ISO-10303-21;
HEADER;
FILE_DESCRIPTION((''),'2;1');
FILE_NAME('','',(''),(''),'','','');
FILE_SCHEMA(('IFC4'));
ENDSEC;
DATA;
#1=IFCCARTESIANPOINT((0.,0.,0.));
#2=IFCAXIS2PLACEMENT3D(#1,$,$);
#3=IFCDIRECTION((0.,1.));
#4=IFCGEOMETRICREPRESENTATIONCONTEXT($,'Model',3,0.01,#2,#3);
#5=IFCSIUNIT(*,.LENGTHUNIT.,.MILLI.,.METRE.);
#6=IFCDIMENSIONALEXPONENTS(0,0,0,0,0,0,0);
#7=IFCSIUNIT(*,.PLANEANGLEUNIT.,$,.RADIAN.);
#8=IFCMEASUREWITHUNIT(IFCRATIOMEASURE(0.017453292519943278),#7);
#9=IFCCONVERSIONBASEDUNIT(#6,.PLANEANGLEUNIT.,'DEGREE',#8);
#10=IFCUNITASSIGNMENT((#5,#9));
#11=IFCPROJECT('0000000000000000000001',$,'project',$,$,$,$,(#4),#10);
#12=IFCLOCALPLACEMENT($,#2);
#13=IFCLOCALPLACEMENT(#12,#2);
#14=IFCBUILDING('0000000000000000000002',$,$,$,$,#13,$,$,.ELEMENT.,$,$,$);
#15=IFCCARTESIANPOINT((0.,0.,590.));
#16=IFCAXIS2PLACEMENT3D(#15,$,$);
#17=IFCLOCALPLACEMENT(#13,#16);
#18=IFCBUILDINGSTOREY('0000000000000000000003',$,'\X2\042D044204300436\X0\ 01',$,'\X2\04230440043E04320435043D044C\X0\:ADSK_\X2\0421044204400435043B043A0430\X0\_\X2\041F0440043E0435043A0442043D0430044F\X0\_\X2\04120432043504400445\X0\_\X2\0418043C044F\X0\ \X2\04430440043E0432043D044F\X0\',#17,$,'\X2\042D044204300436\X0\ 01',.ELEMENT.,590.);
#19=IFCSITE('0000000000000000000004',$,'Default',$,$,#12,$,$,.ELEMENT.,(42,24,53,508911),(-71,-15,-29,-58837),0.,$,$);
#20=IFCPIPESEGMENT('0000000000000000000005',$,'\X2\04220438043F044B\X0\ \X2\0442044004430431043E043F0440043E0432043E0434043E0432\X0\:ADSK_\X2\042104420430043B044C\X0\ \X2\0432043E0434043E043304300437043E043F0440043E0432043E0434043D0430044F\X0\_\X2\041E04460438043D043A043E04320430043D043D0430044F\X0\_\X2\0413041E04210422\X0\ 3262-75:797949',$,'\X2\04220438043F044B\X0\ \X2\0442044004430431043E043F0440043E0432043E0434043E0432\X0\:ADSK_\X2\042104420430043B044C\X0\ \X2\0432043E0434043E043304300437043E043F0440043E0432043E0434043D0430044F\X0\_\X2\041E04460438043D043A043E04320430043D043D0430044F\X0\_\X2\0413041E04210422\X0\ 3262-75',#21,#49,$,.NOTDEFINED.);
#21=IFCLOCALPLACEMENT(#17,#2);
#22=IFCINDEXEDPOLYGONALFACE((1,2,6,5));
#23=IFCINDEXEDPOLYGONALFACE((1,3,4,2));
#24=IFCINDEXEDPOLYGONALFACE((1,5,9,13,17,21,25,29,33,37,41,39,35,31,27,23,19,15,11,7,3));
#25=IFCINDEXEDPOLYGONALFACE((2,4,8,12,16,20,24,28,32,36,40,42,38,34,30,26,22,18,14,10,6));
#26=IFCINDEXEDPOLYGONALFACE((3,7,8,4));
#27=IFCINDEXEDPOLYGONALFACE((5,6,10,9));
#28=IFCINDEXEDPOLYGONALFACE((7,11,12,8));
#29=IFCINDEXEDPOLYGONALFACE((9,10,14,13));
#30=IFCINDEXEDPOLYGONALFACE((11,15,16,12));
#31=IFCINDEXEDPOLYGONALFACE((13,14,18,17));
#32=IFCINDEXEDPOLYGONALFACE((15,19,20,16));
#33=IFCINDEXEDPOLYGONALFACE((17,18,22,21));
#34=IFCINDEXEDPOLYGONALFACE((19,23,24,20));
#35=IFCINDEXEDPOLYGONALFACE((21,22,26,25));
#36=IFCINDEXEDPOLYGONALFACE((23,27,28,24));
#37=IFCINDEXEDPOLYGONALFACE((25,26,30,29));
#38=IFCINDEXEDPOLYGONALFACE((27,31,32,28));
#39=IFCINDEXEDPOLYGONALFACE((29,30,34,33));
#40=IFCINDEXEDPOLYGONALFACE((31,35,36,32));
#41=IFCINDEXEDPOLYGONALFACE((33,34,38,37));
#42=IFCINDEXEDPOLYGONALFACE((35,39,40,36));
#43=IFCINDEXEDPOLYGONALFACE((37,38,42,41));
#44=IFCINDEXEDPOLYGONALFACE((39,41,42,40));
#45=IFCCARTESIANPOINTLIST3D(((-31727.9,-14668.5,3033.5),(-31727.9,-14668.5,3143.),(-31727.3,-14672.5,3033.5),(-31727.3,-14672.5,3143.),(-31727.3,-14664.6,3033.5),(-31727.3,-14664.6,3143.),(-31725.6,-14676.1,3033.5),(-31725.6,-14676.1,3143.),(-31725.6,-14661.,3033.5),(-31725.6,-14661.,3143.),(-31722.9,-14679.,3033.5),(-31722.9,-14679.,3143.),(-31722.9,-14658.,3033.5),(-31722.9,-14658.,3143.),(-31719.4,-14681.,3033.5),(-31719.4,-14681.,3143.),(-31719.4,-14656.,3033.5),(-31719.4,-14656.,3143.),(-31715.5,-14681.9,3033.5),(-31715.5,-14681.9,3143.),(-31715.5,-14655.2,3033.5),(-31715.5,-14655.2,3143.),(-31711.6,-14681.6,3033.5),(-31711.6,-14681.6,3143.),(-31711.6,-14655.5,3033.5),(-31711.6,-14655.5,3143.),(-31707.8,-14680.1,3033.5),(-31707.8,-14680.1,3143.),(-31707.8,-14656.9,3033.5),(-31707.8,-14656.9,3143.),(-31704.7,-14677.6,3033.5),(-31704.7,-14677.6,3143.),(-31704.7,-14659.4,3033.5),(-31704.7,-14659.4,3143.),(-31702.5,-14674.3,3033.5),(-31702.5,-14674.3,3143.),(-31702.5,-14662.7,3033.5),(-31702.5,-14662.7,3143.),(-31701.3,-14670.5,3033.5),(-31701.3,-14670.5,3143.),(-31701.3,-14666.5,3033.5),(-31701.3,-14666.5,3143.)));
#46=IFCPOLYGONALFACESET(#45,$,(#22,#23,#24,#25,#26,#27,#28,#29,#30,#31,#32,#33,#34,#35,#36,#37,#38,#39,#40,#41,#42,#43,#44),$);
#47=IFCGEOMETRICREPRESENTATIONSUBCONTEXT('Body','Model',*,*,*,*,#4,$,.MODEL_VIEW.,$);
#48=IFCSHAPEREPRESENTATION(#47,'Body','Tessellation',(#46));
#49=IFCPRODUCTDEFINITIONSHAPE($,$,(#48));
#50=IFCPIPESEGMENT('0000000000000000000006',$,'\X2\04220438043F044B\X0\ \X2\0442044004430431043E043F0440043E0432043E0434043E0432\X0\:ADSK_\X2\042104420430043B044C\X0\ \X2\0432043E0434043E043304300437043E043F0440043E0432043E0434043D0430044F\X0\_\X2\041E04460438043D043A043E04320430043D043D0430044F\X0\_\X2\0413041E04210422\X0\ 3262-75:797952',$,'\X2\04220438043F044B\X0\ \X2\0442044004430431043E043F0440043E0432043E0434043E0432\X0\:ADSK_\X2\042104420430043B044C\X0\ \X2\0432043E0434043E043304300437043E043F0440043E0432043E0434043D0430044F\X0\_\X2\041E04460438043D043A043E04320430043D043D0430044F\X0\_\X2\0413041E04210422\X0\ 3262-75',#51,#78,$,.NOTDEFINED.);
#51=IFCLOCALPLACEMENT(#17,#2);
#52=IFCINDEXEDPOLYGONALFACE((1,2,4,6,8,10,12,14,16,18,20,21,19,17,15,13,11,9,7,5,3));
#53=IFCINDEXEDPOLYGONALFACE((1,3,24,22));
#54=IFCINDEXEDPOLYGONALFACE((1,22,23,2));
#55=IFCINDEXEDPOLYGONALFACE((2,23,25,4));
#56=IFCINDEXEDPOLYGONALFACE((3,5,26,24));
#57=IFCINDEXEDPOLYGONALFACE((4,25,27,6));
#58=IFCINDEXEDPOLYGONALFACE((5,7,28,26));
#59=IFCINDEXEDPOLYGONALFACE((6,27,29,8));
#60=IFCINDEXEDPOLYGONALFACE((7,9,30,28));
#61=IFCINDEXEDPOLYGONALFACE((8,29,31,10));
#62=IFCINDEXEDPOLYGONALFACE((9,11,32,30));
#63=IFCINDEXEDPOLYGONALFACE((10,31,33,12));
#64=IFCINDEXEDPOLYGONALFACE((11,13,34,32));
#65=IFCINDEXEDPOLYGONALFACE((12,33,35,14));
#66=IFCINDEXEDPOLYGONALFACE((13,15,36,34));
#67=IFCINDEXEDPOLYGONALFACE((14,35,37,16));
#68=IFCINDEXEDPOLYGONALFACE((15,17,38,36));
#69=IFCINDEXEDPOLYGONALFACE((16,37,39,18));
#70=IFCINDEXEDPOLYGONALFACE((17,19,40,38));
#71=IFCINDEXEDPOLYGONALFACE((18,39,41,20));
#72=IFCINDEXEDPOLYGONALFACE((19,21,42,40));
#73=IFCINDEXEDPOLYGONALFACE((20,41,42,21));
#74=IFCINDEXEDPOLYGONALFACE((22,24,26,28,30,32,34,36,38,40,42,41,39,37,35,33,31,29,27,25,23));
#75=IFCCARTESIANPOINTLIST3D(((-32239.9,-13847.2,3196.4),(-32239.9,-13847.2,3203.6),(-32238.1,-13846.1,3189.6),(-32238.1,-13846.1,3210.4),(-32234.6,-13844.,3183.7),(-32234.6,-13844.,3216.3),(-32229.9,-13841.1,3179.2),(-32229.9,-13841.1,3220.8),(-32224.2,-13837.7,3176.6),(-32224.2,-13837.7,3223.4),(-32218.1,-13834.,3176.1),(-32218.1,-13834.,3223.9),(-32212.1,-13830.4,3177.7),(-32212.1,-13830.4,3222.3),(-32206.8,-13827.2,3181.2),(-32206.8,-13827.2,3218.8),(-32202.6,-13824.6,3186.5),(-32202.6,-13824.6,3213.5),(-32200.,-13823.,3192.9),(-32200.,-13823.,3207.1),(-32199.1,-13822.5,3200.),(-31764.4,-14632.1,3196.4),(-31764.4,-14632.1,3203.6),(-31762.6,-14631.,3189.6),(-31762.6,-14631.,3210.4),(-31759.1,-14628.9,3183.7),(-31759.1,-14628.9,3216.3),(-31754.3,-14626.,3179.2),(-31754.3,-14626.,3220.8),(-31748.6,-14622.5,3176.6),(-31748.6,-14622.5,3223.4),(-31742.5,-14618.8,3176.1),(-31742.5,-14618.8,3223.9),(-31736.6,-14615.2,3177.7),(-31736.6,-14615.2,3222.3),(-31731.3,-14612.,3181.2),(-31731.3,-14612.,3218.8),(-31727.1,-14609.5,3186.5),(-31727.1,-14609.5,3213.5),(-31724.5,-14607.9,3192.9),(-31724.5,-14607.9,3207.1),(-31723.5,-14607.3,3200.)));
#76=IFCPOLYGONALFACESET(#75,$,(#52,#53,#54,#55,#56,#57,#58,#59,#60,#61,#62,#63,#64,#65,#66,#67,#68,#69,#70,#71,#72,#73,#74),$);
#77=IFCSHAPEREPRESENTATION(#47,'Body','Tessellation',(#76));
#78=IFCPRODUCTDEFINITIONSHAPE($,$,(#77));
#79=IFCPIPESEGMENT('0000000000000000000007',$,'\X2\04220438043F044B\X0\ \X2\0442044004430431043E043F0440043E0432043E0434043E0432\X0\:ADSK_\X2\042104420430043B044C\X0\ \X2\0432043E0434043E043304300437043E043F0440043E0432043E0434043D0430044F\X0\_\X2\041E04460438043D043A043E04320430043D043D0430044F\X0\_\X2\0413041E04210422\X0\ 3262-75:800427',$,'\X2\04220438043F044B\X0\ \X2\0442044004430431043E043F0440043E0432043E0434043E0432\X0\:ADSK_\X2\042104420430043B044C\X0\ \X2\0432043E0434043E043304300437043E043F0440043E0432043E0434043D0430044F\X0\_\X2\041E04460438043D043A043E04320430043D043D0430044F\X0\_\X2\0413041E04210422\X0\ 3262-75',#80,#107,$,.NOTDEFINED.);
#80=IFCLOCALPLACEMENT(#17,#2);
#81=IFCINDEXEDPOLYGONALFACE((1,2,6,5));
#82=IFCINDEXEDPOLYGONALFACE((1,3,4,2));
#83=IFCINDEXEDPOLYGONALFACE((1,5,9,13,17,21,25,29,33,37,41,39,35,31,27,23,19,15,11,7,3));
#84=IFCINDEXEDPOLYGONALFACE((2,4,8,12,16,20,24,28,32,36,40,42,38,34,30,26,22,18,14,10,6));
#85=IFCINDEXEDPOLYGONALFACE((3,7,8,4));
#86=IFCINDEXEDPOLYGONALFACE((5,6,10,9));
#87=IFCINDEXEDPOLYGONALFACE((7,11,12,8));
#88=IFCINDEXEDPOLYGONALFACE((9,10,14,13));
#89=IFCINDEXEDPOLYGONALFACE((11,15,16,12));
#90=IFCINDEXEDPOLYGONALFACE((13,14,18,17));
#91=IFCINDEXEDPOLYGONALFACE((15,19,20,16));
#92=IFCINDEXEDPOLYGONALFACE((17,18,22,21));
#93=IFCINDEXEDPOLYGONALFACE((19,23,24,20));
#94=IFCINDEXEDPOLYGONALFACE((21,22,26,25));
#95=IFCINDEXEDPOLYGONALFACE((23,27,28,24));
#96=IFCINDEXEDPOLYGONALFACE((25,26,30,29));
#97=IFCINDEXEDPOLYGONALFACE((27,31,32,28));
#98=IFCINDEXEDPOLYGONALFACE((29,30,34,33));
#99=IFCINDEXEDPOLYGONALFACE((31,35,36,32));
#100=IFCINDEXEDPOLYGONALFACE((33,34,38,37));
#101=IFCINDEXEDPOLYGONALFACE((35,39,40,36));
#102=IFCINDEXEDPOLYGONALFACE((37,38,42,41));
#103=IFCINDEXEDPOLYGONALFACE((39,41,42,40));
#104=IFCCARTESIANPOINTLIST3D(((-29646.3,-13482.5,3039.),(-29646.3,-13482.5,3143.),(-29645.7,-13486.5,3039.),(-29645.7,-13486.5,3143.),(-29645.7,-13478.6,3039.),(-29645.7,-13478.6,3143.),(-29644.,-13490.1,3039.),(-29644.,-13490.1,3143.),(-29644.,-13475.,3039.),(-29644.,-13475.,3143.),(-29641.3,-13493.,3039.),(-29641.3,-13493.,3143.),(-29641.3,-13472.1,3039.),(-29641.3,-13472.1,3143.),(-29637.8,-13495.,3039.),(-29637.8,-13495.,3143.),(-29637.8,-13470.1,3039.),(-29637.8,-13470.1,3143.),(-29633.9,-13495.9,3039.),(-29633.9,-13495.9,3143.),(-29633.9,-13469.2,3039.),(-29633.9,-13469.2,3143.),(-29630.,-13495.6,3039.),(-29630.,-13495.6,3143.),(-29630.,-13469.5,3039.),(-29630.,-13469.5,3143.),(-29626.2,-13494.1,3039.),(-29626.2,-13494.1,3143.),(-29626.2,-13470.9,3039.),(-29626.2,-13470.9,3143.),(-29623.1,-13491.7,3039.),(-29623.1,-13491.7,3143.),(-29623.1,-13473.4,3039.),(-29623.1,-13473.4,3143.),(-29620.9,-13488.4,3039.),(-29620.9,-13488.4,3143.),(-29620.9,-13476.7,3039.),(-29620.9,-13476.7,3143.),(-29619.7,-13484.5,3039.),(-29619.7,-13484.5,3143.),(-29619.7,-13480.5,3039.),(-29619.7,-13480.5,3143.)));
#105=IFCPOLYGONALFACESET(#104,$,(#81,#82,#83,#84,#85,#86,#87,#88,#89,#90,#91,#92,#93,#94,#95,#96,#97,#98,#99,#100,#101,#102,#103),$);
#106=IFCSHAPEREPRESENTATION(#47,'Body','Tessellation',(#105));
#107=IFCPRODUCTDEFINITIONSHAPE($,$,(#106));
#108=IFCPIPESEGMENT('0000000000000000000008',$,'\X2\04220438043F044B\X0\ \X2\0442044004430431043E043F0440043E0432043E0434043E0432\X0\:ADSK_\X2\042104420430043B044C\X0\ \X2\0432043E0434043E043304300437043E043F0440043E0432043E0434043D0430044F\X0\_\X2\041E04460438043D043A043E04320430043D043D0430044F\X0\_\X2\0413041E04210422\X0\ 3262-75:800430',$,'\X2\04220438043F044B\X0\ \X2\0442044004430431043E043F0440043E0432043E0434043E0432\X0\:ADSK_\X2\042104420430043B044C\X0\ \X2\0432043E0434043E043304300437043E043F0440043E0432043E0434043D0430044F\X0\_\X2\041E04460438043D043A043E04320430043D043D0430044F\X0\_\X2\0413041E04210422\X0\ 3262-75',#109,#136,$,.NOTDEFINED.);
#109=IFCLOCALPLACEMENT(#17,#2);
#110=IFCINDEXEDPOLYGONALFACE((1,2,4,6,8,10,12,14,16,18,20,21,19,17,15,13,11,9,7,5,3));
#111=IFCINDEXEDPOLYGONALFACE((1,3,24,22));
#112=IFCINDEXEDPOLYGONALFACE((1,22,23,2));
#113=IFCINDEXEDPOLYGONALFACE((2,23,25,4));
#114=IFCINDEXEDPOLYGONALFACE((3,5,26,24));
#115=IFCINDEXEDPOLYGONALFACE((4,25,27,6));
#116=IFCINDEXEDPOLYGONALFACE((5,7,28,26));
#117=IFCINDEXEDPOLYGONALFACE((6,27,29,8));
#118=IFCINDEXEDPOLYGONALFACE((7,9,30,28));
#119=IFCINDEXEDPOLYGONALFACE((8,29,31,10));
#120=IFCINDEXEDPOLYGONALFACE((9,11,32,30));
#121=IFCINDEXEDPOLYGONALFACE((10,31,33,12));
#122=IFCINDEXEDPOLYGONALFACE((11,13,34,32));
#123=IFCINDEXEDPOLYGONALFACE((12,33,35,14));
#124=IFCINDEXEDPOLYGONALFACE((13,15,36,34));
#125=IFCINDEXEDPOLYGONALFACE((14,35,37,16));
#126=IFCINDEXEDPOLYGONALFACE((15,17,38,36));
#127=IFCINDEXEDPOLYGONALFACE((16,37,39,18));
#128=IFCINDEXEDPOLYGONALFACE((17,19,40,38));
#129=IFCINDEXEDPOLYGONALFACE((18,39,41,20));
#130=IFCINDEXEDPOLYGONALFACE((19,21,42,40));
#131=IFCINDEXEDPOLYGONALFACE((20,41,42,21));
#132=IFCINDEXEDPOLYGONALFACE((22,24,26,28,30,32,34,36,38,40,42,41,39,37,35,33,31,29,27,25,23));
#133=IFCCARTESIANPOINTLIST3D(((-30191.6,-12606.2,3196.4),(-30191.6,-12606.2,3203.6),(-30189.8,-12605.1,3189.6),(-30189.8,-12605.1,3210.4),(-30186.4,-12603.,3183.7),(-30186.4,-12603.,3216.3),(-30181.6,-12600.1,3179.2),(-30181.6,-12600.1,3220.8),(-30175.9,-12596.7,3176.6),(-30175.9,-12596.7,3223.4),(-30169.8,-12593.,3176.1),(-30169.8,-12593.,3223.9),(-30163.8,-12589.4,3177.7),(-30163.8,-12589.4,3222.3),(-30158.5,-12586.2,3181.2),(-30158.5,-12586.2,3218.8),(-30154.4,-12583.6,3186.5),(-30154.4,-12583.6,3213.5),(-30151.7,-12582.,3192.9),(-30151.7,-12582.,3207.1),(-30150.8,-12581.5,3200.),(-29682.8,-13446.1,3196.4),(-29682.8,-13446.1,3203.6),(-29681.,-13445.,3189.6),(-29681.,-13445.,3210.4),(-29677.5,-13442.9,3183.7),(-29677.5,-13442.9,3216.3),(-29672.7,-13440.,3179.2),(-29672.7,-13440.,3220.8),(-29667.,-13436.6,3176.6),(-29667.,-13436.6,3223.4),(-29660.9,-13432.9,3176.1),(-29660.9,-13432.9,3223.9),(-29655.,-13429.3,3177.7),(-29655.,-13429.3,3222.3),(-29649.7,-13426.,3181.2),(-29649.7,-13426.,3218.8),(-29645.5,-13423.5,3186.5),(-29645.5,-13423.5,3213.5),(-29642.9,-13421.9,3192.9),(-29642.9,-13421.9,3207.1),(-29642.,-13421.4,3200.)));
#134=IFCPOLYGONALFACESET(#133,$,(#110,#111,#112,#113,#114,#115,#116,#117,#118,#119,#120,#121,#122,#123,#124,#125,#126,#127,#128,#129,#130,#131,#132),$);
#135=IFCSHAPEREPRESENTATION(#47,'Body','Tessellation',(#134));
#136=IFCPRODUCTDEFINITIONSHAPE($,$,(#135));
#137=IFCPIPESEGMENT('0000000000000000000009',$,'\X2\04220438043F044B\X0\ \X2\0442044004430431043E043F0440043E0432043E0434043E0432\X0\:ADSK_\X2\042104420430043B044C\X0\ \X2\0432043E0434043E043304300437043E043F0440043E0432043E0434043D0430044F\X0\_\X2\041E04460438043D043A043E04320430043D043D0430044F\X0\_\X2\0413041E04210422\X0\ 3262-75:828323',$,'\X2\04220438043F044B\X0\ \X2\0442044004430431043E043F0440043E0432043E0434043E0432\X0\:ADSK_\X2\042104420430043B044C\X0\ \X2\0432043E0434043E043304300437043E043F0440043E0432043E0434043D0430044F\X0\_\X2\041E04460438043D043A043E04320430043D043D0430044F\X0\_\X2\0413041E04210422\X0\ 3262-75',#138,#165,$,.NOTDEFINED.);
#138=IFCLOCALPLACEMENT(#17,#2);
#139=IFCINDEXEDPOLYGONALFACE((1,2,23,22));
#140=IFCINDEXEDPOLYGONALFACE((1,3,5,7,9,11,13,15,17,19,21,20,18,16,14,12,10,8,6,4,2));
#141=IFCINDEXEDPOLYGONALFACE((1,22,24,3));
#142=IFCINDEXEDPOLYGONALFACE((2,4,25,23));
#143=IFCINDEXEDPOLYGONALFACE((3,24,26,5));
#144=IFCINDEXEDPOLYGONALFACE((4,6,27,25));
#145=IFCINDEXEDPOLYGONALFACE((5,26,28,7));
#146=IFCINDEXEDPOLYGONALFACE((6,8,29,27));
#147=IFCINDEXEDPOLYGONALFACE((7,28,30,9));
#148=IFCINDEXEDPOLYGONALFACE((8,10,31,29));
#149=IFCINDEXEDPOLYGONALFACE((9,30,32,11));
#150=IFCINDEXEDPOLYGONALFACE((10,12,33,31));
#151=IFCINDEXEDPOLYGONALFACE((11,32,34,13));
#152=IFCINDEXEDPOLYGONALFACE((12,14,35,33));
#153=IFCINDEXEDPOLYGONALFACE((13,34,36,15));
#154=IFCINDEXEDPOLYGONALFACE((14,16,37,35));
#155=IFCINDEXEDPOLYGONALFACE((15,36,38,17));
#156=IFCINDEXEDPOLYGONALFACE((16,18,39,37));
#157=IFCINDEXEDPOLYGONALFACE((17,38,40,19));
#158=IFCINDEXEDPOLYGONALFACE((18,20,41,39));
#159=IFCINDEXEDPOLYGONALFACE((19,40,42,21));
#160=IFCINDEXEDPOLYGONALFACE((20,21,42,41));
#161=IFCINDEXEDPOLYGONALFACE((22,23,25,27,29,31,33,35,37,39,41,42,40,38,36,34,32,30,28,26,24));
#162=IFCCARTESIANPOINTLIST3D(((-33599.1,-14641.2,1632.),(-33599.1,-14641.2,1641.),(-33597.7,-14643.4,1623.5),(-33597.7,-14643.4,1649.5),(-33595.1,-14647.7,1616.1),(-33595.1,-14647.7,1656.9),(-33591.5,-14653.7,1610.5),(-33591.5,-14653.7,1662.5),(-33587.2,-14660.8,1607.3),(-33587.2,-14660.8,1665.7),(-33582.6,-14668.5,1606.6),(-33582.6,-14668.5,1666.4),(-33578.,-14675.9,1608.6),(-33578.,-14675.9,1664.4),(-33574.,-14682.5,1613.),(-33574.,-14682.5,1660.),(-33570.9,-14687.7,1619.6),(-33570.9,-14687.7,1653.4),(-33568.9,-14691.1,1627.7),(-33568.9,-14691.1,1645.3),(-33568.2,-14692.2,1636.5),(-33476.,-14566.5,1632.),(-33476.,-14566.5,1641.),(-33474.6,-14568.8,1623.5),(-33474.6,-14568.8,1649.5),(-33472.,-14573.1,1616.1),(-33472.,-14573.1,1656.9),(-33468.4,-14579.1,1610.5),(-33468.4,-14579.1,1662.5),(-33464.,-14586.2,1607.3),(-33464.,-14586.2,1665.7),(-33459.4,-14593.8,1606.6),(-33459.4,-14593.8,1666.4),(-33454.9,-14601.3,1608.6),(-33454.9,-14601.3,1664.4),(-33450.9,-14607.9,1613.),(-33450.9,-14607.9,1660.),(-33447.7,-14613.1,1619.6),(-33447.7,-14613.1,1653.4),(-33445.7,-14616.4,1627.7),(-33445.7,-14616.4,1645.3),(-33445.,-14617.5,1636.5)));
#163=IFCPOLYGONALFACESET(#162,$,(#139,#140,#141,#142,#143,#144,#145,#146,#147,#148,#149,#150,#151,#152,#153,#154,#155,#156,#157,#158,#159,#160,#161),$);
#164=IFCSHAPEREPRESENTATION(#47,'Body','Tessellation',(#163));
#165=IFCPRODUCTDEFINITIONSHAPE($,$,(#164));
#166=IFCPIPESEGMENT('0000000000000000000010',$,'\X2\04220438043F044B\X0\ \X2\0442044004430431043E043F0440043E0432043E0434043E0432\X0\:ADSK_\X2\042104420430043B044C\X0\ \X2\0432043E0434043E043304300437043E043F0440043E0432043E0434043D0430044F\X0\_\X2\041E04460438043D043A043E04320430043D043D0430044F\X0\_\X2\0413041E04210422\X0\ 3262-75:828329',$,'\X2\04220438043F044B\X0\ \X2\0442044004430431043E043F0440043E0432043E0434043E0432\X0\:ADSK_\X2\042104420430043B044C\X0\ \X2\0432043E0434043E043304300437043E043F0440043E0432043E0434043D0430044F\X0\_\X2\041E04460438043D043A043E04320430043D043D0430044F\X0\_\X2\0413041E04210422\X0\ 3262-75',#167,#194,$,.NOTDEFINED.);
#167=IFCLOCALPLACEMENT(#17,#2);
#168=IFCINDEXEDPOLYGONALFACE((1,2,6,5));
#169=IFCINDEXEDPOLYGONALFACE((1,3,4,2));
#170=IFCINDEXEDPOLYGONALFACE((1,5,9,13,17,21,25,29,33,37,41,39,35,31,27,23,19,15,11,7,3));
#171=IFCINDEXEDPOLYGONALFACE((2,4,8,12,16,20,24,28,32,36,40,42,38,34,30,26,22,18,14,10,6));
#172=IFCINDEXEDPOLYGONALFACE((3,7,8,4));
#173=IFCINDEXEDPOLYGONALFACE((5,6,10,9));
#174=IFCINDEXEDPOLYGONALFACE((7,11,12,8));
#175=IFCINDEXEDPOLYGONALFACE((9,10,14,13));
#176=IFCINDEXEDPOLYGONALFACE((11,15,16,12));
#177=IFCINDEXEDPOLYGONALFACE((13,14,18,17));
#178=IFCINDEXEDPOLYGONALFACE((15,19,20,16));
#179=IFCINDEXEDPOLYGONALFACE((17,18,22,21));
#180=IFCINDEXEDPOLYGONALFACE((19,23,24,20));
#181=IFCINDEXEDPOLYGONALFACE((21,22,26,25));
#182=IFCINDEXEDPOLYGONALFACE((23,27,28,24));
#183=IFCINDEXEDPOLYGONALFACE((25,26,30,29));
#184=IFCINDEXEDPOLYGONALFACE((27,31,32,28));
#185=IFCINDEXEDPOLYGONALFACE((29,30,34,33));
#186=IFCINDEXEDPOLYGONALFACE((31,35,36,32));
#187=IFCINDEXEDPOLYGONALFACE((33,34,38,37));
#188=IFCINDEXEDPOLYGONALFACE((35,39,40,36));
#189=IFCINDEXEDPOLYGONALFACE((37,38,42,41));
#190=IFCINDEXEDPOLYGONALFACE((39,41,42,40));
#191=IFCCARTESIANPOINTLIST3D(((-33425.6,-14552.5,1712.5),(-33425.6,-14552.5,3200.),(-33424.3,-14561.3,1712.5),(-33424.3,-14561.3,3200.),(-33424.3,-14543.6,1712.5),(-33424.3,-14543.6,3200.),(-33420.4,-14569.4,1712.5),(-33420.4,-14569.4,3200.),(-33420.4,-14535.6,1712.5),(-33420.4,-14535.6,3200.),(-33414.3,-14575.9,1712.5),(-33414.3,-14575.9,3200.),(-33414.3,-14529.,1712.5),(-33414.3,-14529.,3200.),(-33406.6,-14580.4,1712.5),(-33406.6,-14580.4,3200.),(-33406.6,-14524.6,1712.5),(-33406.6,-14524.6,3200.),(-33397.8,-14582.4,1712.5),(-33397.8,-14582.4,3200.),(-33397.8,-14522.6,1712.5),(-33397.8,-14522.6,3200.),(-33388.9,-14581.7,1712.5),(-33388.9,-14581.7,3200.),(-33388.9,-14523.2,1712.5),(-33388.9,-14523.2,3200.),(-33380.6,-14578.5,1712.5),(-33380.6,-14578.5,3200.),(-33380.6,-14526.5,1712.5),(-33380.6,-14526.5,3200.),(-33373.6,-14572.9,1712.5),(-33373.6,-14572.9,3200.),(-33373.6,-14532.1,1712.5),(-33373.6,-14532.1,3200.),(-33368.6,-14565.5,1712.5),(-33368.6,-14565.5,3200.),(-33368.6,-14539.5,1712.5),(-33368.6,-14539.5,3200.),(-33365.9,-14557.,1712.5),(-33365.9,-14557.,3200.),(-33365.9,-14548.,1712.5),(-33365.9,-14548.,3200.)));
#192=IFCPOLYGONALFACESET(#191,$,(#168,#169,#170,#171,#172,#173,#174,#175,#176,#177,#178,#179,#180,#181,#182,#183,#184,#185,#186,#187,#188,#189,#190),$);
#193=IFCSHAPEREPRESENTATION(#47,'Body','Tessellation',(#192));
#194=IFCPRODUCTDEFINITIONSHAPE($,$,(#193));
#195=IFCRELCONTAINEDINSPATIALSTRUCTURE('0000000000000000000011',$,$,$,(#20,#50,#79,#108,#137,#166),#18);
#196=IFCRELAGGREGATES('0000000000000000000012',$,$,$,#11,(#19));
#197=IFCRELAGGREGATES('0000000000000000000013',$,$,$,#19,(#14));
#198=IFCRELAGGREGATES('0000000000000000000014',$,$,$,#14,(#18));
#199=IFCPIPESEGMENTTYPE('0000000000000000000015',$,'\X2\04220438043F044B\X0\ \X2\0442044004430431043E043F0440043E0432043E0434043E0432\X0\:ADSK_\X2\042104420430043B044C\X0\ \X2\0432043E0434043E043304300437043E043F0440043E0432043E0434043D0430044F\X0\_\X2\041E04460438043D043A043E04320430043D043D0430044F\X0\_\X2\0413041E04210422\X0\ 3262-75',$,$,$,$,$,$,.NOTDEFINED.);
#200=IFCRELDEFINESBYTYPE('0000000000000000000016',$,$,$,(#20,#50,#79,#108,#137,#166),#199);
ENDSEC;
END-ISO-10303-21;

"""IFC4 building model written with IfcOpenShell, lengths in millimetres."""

from ifc_helpers import new_model, entity, si_unit, converted_unit, direction, frame, frame_2d, origin, origin_2d_with_axis, place, context, subcontext, project, spatial, circle, extrude, type_object, element, save


model = new_model("IFC4")

# Units and contexts
model_context = context("Model", 3, precision=0.01, world=origin(), true_north=direction((0.0, 1.0)))
body_context = subcontext(model_context, "Body", "Model", "MODEL_VIEW")
ifc_project = project(units=[si_unit("LENGTHUNIT", "METRE", prefix="MILLI"), converted_unit("PLANEANGLEUNIT", "DEGREE", entity("IfcRatioMeasure", 0.017453292519943278), si_unit("PLANEANGLEUNIT", "RADIAN"), dimensions=[0, 0, 0, 0, 0, 0, 0])], contexts=[model_context])

# Site, building, storey
site_placement = place(None, origin())
site = spatial("IfcSite", under=ifc_project, at=site_placement, Name="Default", CompositionType="ELEMENT", RefLatitude=(42, 24, 53, 508911), RefLongitude=(-71, -15, -29, -58837), RefElevation=0.0)
building_placement = place(site_placement, origin())
building = spatial("IfcBuilding", under=site, at=building_placement, CompositionType="ELEMENT")
storey_placement = place(building_placement, frame((0.0, 0.0, 590.0)))
storey = spatial("IfcBuildingStorey", under=building, at=storey_placement, Name="Этаж 01", ObjectType="Уровень:ADSK_Стрелка_Проектная_Вверх_Имя уровня", LongName="Этаж 01", CompositionType="ELEMENT", Elevation=590.0)

# Pipe segments
pipe_segment_type = type_object("IfcPipeSegmentType", Name="Типы трубопроводов:ADSK_Сталь водогазопроводная_Оцинкованная_ГОСТ 3262-75", PredefinedType="NOTDEFINED")
pipe_segment_1_placement = place(storey_placement, frame((-31729.5, -14683.5, 3143.0)))
element("IfcPipeSegment", 1, at=pipe_segment_1_placement, inside=storey, type_object=pipe_segment_type, Name="Типы трубопроводов:ADSK_Сталь водогазопроводная_Оцинкованная_ГОСТ 3262-75:797949", ObjectType="Типы трубопроводов:ADSK_Сталь водогазопроводная_Оцинкованная_ГОСТ 3262-75", PredefinedType="NOTDEFINED", context=body_context, shape_type="SweptSolid", body=[
    extrude(circle(Radius=13.4, at=frame_2d((0.0, 0.0), x_axis=(1.0, 0.0))), frame((15.0, 15.0, -109.5), z_axis=(0.0, 0.0, 1.0), x_axis=(-1.0, 0.0, 0.0)), (0.0, 0.0, 1.0), 109.5),
])
pipe_segment_2_placement = place(storey_placement, frame((-32241.7, -14633.8, 3174.4)))
element("IfcPipeSegment", 2, at=pipe_segment_2_placement, inside=storey, type_object=pipe_segment_type, Name="Типы трубопроводов:ADSK_Сталь водогазопроводная_Оцинкованная_ГОСТ 3262-75:797952", ObjectType="Типы трубопроводов:ADSK_Сталь водогазопроводная_Оцинкованная_ГОСТ 3262-75", PredefinedType="NOTDEFINED", context=body_context, shape_type="SweptSolid", body=[
    extrude(circle(Radius=24.0, at=origin_2d_with_axis()), frame((22.1, 798.9, 25.6), z_axis=(0.518188, -0.855267, 0.0), x_axis=(0.855267, 0.518188, 0.0)), (0.0, 0.0, 1.0), 917.7),
])
pipe_segment_3_placement = place(storey_placement, frame((-29647.9, -13497.5, 3143.0)))
element("IfcPipeSegment", 3, at=pipe_segment_3_placement, inside=storey, type_object=pipe_segment_type, Name="Типы трубопроводов:ADSK_Сталь водогазопроводная_Оцинкованная_ГОСТ 3262-75:800427", ObjectType="Типы трубопроводов:ADSK_Сталь водогазопроводная_Оцинкованная_ГОСТ 3262-75", PredefinedType="NOTDEFINED", context=body_context, shape_type="SweptSolid", body=[
    extrude(circle(Radius=13.4, at=origin_2d_with_axis()), frame((15.0, 15.0, -104.0), z_axis=(0.0, 0.0, 1.0), x_axis=(-1.0, 0.0, 0.0)), (0.0, 0.0, 1.0), 104.0),
])
pipe_segment_4_placement = place(storey_placement, frame((-30193.5, -13447.8, 3174.4)))
element("IfcPipeSegment", 4, at=pipe_segment_4_placement, inside=storey, type_object=pipe_segment_type, Name="Типы трубопроводов:ADSK_Сталь водогазопроводная_Оцинкованная_ГОСТ 3262-75:800430", ObjectType="Типы трубопроводов:ADSK_Сталь водогазопроводная_Оцинкованная_ГОСТ 3262-75", PredefinedType="NOTDEFINED", context=body_context, shape_type="SweptSolid", body=[
    extrude(circle(Radius=24.0, at=origin_2d_with_axis()), frame((22.1, 853.9, 25.6), z_axis=(0.518188, -0.855267, 0.0), x_axis=(0.855267, 0.518188, 0.0)), (0.0, 0.0, 1.0), 982.0),
])
pipe_segment_5_placement = place(storey_placement, frame((-33600.9, -14693.8, 1668.1)))
element("IfcPipeSegment", 5, at=pipe_segment_5_placement, inside=storey, type_object=pipe_segment_type, Name="Типы трубопроводов:ADSK_Сталь водогазопроводная_Оцинкованная_ГОСТ 3262-75:828323", ObjectType="Типы трубопроводов:ADSK_Сталь водогазопроводная_Оцинкованная_ГОСТ 3262-75", PredefinedType="NOTDEFINED", context=body_context, shape_type="SweptSolid", body=[
    extrude(circle(Radius=30.0, at=frame_2d((0.0, 0.0), x_axis=(1.0, 0.0))), frame((17.1, 27.2, -31.6), z_axis=(0.855102, 0.51846, 0.0), x_axis=(0.51846, -0.855102, 0.0)), (0.0, 0.0, 1.0), 144.0),
])
pipe_segment_6_placement = place(storey_placement, frame((-33427.2, -14584.1, 3200.0)))
element("IfcPipeSegment", 6, at=pipe_segment_6_placement, inside=storey, type_object=pipe_segment_type, Name="Типы трубопроводов:ADSK_Сталь водогазопроводная_Оцинкованная_ГОСТ 3262-75:828329", ObjectType="Типы трубопроводов:ADSK_Сталь водогазопроводная_Оцинкованная_ГОСТ 3262-75", PredefinedType="NOTDEFINED", context=body_context, shape_type="SweptSolid", body=[
    extrude(circle(Radius=30.0, at=origin_2d_with_axis()), frame((31.6, 31.6, -1487.5), z_axis=(0.0, 0.0, 1.0), x_axis=(-1.0, 0.0, 0.0)), (0.0, 0.0, 1.0), 1487.5),
])

save(model, "model.ifc")
